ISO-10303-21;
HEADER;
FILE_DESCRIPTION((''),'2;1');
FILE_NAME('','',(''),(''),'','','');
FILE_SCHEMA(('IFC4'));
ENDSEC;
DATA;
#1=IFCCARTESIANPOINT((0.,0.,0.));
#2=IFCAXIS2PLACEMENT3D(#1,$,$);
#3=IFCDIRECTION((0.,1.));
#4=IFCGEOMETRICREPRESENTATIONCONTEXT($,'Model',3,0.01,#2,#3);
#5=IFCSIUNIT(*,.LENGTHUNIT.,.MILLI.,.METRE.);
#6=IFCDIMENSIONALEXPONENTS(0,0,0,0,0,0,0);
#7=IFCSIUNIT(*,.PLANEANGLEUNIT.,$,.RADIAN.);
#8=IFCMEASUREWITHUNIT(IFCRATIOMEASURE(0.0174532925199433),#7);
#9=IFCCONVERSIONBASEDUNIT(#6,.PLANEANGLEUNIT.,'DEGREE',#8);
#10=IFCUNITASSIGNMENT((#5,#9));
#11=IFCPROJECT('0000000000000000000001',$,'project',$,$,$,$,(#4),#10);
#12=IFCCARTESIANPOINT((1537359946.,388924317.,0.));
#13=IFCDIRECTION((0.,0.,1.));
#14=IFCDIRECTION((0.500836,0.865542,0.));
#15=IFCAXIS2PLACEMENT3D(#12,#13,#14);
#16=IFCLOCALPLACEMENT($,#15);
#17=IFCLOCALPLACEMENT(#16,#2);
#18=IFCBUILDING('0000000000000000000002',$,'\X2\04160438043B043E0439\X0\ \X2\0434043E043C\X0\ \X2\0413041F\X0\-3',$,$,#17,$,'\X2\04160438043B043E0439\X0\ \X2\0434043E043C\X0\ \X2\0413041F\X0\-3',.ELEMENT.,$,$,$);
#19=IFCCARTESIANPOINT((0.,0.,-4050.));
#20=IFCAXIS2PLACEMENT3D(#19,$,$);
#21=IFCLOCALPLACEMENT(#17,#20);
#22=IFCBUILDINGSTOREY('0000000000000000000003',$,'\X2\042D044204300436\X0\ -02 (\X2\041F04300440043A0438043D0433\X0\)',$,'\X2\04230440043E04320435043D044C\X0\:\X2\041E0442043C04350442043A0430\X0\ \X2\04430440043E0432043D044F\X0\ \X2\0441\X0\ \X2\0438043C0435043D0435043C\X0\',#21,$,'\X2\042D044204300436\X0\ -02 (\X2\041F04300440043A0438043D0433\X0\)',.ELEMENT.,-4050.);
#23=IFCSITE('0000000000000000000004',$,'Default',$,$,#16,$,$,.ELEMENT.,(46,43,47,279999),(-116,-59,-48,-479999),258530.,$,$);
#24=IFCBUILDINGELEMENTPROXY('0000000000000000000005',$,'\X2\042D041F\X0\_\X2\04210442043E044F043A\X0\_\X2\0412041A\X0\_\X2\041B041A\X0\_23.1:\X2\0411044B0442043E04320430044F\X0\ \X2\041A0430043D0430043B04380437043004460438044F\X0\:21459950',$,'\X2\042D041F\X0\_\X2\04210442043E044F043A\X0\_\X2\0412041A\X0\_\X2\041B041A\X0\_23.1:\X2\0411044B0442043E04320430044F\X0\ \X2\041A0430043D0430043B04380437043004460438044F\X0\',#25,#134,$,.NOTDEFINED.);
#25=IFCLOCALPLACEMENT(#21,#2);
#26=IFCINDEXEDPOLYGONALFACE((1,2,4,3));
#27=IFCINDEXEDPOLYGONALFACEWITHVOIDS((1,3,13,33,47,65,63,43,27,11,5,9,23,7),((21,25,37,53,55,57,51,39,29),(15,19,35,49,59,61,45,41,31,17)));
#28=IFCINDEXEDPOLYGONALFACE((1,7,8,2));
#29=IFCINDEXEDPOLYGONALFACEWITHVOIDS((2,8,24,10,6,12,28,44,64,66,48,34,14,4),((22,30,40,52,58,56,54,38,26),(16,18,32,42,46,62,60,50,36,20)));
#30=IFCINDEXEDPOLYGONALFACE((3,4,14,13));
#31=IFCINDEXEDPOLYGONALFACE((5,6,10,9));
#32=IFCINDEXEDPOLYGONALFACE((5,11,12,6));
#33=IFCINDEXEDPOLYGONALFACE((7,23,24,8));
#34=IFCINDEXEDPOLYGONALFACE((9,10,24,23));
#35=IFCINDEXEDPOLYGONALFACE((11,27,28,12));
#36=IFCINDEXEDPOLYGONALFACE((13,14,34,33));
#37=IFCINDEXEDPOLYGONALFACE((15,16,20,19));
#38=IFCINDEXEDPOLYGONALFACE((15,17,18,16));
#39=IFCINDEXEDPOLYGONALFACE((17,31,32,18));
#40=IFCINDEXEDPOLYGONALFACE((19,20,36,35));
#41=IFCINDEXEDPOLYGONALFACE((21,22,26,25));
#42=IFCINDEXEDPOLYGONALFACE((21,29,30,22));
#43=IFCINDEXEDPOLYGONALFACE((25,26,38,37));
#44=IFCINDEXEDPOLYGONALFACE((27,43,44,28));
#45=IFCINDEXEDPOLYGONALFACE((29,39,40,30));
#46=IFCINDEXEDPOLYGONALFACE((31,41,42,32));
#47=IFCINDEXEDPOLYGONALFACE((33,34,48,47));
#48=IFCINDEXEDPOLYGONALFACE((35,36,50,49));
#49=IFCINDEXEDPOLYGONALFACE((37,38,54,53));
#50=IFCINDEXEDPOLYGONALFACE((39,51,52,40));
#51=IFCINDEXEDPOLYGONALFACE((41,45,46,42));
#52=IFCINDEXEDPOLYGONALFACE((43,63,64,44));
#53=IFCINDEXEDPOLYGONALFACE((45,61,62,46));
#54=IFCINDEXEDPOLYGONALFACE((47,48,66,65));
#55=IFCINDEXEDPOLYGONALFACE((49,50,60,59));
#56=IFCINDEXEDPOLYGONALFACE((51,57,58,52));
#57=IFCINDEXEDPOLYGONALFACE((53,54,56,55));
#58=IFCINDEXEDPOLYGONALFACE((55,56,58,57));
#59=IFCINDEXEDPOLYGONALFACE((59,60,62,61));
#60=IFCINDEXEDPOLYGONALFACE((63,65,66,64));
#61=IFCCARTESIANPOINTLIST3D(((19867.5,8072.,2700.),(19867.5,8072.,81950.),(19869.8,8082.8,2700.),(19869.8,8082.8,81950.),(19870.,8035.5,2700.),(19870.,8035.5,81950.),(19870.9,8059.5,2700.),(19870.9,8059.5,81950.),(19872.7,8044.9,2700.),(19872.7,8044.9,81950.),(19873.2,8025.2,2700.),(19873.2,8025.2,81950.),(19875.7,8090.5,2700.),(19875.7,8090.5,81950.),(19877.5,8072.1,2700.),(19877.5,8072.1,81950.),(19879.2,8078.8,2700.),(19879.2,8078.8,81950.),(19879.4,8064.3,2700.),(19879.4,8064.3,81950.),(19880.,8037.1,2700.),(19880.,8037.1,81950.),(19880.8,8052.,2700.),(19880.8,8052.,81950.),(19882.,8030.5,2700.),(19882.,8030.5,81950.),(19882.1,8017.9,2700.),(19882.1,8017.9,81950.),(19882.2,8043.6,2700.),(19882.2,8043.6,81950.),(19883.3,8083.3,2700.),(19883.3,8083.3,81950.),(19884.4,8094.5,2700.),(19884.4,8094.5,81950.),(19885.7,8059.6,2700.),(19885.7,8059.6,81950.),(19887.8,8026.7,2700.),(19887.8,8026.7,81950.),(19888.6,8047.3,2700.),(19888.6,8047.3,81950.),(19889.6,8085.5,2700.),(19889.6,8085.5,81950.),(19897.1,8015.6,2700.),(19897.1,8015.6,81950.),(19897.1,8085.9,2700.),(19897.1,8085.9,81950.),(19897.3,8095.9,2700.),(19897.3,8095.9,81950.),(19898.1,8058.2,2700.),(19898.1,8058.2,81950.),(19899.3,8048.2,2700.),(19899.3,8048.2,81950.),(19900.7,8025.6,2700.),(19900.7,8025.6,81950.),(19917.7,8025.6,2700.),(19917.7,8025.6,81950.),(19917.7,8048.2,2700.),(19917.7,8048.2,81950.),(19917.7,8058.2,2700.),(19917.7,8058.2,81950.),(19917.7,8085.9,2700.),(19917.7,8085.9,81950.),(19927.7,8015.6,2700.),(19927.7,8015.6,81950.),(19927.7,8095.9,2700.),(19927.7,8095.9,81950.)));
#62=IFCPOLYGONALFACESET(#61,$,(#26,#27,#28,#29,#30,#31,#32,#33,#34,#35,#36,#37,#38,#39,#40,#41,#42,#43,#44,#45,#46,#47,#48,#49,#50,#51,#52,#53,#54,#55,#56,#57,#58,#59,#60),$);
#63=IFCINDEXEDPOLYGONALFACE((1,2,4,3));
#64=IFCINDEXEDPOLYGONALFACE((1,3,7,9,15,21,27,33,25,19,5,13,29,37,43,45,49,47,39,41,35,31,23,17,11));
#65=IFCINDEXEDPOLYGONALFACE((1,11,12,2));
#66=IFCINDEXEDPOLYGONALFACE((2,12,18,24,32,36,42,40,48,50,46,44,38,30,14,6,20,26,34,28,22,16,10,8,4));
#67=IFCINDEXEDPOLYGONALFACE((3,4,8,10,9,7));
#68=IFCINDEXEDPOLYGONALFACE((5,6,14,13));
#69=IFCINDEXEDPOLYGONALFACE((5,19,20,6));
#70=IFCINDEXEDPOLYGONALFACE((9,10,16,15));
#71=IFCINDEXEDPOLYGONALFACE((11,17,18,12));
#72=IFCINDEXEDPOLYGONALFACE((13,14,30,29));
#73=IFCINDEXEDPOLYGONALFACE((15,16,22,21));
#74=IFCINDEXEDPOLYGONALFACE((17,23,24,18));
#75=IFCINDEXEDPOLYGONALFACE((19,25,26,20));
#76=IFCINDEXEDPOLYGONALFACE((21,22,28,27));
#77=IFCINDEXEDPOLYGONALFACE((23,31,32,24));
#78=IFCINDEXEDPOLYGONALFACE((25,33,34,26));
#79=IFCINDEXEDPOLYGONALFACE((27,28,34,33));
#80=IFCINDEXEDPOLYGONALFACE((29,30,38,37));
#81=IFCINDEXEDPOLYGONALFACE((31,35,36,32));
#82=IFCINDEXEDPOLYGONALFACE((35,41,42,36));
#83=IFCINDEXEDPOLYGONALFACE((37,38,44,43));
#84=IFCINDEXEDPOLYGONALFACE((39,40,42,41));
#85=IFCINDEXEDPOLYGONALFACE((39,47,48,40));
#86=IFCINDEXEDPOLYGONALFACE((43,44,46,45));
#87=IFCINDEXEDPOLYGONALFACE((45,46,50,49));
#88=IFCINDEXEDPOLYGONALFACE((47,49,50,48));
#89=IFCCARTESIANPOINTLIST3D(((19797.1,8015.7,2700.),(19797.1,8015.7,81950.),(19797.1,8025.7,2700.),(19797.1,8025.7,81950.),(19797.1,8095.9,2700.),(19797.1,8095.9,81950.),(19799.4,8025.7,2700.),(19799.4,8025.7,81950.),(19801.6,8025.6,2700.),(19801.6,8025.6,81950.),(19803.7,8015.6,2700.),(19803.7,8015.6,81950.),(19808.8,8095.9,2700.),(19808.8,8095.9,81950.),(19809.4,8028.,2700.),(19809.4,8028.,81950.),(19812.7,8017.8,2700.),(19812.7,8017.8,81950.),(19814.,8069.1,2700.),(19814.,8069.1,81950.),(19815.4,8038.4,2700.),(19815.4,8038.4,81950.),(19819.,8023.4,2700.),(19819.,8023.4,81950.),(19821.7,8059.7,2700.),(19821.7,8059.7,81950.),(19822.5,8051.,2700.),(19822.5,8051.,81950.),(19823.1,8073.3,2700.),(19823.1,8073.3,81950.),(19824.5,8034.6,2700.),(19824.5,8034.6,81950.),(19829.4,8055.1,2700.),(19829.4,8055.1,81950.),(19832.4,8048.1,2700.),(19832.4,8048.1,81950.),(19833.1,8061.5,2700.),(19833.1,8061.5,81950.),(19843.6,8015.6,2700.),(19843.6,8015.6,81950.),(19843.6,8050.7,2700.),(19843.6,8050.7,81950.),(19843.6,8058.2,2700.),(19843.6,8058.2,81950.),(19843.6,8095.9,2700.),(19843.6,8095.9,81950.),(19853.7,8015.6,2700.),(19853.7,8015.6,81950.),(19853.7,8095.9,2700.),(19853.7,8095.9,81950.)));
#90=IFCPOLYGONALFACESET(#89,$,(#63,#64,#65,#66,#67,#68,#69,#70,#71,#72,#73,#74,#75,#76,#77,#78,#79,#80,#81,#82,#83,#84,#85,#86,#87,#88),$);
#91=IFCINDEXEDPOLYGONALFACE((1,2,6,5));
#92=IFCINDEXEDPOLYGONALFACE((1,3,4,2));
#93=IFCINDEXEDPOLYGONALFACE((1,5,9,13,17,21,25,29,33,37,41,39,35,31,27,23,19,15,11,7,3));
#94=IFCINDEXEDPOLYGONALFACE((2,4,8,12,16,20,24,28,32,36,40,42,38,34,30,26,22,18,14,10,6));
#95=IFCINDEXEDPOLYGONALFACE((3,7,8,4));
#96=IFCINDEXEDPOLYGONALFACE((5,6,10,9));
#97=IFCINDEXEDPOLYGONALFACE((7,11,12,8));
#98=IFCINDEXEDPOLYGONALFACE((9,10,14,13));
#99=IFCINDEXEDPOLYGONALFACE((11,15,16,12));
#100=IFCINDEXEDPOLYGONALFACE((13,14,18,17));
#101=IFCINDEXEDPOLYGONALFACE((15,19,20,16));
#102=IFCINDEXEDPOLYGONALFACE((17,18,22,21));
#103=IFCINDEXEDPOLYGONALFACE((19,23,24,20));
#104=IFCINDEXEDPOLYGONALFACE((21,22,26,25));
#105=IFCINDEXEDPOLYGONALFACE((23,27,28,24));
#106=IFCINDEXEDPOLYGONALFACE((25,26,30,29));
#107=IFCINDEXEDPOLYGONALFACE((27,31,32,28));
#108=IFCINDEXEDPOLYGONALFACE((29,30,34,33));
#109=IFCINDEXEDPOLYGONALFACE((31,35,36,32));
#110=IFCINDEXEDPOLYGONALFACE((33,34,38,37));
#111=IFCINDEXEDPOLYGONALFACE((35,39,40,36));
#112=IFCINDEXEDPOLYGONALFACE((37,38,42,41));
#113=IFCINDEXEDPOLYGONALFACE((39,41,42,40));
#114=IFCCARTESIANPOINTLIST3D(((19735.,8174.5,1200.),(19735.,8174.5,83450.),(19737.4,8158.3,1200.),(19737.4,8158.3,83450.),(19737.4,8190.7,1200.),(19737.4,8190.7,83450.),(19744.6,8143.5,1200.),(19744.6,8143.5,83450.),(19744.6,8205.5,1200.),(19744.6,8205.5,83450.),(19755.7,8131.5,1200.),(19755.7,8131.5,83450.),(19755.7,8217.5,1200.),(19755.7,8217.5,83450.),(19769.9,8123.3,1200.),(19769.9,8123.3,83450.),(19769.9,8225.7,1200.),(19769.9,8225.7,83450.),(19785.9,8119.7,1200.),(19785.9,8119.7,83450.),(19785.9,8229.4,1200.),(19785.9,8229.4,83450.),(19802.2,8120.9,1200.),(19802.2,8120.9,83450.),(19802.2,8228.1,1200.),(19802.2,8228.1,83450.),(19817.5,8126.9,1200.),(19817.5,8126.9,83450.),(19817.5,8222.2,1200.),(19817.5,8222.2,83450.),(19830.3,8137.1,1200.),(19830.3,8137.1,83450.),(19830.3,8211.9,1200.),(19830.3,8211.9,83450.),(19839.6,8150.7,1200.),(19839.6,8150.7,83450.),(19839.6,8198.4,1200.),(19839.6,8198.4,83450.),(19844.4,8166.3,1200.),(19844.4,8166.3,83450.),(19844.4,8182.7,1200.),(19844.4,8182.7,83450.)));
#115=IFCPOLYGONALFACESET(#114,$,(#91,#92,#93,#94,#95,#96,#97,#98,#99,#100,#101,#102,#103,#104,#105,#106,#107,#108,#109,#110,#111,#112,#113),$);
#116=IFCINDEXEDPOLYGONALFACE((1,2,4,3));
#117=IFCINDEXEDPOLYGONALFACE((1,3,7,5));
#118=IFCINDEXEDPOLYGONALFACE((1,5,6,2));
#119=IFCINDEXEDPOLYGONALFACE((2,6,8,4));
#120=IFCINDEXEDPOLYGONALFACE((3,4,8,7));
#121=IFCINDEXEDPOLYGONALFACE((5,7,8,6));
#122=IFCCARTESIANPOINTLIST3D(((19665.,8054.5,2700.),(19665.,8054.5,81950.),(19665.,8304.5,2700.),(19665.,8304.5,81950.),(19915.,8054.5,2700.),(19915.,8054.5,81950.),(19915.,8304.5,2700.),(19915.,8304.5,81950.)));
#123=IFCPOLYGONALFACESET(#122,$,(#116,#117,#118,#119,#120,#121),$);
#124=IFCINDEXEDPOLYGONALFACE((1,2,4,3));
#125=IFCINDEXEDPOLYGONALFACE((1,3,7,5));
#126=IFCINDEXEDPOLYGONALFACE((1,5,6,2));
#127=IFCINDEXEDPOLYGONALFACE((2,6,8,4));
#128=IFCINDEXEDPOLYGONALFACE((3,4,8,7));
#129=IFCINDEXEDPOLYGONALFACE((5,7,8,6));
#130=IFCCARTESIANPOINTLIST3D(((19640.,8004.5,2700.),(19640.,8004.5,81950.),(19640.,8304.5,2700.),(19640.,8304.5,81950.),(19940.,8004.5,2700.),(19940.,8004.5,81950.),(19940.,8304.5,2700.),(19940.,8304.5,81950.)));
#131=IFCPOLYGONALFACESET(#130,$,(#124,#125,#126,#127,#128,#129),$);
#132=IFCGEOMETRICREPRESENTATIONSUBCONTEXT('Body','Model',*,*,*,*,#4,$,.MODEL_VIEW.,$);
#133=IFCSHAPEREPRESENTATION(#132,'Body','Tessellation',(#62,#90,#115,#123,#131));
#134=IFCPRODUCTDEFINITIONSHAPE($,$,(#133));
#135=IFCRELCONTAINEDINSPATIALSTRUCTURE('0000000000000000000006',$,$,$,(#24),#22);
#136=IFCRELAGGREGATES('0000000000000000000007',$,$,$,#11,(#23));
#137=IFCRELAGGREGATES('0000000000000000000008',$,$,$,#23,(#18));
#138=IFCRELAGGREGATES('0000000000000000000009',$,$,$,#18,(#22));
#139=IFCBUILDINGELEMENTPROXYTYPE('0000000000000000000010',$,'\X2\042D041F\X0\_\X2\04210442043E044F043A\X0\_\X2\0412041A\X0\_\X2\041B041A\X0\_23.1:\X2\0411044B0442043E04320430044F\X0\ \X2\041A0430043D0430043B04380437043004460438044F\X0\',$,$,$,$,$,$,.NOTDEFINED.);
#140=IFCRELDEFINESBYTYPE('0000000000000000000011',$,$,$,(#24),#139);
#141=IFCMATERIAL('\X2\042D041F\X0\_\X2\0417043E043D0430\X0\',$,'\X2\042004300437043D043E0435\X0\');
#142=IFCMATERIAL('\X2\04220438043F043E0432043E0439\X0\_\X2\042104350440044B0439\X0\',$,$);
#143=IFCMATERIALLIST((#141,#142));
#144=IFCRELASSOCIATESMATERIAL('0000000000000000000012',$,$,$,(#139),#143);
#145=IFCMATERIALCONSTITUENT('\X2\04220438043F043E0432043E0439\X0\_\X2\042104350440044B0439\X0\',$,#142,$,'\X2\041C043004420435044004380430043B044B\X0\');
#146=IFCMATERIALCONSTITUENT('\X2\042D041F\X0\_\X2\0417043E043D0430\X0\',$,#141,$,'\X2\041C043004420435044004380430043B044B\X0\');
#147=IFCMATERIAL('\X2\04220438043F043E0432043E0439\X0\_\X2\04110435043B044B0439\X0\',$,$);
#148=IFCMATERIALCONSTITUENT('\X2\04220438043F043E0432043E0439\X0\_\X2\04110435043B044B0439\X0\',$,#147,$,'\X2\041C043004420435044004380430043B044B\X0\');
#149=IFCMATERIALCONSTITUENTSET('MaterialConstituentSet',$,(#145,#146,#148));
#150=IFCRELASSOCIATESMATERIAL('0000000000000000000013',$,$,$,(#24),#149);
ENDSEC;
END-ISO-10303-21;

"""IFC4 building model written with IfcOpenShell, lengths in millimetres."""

from ifc_helpers import new_model, entity, si_unit, converted_unit, direction, frame, frame_2d, origin, place, context, subcontext, project, spatial, polyline, rectangle, circle, outline, extrude, source, transform, mapped, material, material_list, constituent, constituent_set, type_object, type_shapes, element, save


model = new_model("IFC4")

# Units and contexts
model_context = context("Model", 3, precision=0.01, world=origin(), true_north=direction((0.0, 1.0)))
body_context = subcontext(model_context, "Body", "Model", "MODEL_VIEW")
ifc_project = project(units=[si_unit("LENGTHUNIT", "METRE", prefix="MILLI"), converted_unit("PLANEANGLEUNIT", "DEGREE", entity("IfcRatioMeasure", 0.0174532925199433), si_unit("PLANEANGLEUNIT", "RADIAN"), dimensions=[0, 0, 0, 0, 0, 0, 0])], contexts=[model_context])

# Site, building, storey
site_placement = place(None, frame((1537359946.0, 388924317.0, 0.0), z_axis=(0.0, 0.0, 1.0), x_axis=(0.500836, 0.865542, 0.0)))
site = spatial("IfcSite", under=ifc_project, at=site_placement, Name="Default", CompositionType="ELEMENT", RefLatitude=(46, 43, 47, 279999), RefLongitude=(-116, -59, -48, -479999), RefElevation=258530.0)
building_placement = place(site_placement, origin())
building = spatial("IfcBuilding", under=site, at=building_placement, Name="Жилой дом ГП-3", LongName="Жилой дом ГП-3", CompositionType="ELEMENT")
storey_placement = place(building_placement, frame((0.0, 0.0, -4050.0)))
storey = spatial("IfcBuildingStorey", under=building, at=storey_placement, Name="Этаж -02 (Паркинг)", ObjectType="Уровень:Отметка уровня с именем", LongName="Этаж -02 (Паркинг)", CompositionType="ELEMENT", Elevation=-4050.0)

# Building element proxy
ifc_material_1 = material(Name="ЭП_Зона", Category="Разное")
ifc_material_2 = material(Name="Типовой_Белый")
ifc_material_3 = material(Name="Типовой_Серый")
ifc_constituent_1 = constituent(ifc_material_3, Name="Типовой_Серый", Category="Материалы")
ifc_constituent_2 = constituent(ifc_material_1, Name="ЭП_Зона", Category="Материалы")
ifc_constituent_3 = constituent(ifc_material_2, Name="Типовой_Белый", Category="Материалы")
ifc_constituent_set_1 = constituent_set(constituents=[ifc_constituent_1, ifc_constituent_2, ifc_constituent_3], Name="MaterialConstituentSet")
ifc_material_list_1 = material_list([ifc_material_1, ifc_material_3])
building_element_proxy_type_1 = type_object("IfcBuildingElementProxyType", Name="ЭП_Стояк_ВК_ЛК_23.1:Бытовая Канализация", PredefinedType="NOTDEFINED", material=ifc_material_list_1)
shared_shape_1 = source(origin(), body_context, "Body", "SweptSolid", [
    extrude(outline(polyline([(-42.2, -39.0), (-11.8, -39.0), (1.1, -37.6), (9.8, -33.5), (15.7, -25.8), (18.0, -15.0), (14.6, -2.5), (4.7, 5.0), (12.8, 12.1), (15.5, 21.5), (12.3, 31.8), (3.4, 39.0), (-11.6, 41.4), (-42.2, 41.4), (-42.2, -39.0)]), holes=[polyline([(-32.2, 8.8), (-32.2, 31.4), (-15.2, 31.4), (-2.3, 30.3), (3.5, 26.4), (5.5, 19.9), (3.3, 13.3), (-3.1, 9.6), (-13.9, 8.8), (-32.2, 8.8)]), polyline([(-32.2, -28.9), (-32.2, -1.3), (-12.6, -1.3), (-0.2, -2.6), (6.1, -7.3), (8.0, -15.1), (6.3, -21.9), (2.2, -26.3), (-4.1, -28.5), (-11.6, -28.9), (-32.2, -28.9)])]), frame((54.5, -52.4, -1350.0)), (0.0, 0.0, 1.0), 79250.0),
    extrude(outline(polyline([(-32.1, -31.9), (48.3, -31.9), (48.3, -21.8), (10.6, -21.8), (13.8, -11.4), (25.6, -1.3), (48.3, 13.0), (48.3, 24.6), (21.4, 7.7), (12.0, 0.1), (7.4, -7.7), (3.3, -0.7), (-9.3, 6.4), (-19.7, 12.3), (-22.1, 20.2), (-22.0, 22.4), (-22.0, 24.6), (-32.0, 24.6), (-32.1, 18.0), (-29.9, 9.0), (-24.3, 2.8), (-13.1, -2.8), (0.4, -10.6), (3.0, -21.8), (-32.1, -21.8), (-32.1, -31.9)])), frame((118.2, -43.1, -1350.0), z_axis=(0.0, 0.0, 1.0), x_axis=(0.0, -1.0, 0.0)), (0.0, 0.0, 1.0), 79250.0),
    extrude(circle(Radius=55.0, at=frame_2d((0.0, 0.0), x_axis=(1.0, 0.0))), frame((150.0, -170.0, -2850.0)), (0.0, 0.0, 1.0), 82250.0),
    extrude(rectangle(XDim=250.0, YDim=250.0, at=frame_2d((0.0, 0.0), x_axis=(1.0, 0.0))), frame((150.0, -175.0, -1350.0)), (0.0, 0.0, 1.0), 79250.0),
    extrude(rectangle(XDim=300.0, YDim=300.0, at=frame_2d((0.0, 0.0), x_axis=(1.0, 0.0))), frame((150.0, -150.0, -1350.0)), (0.0, 0.0, 1.0), 79250.0),
])
type_shapes(building_element_proxy_type_1, [shared_shape_1])
proxy_1_placement = place(storey_placement, frame((19940.0, 8004.5, 4050.0), z_axis=(0.0, 0.0, 1.0), x_axis=(-1.0, 0.0, 0.0)))
element("IfcBuildingElementProxy", 1, at=proxy_1_placement, inside=storey, type_object=building_element_proxy_type_1, material=ifc_constituent_set_1, Name="ЭП_Стояк_ВК_ЛК_23.1:Бытовая Канализация:21459950", ObjectType="ЭП_Стояк_ВК_ЛК_23.1:Бытовая Канализация", PredefinedType="NOTDEFINED", context=body_context, shape_type="MappedRepresentation", body=[
    mapped(shared_shape_1, transform((0.0, 0.0, 0.0), scale=1.0)),
])

save(model, "model.ifc")
